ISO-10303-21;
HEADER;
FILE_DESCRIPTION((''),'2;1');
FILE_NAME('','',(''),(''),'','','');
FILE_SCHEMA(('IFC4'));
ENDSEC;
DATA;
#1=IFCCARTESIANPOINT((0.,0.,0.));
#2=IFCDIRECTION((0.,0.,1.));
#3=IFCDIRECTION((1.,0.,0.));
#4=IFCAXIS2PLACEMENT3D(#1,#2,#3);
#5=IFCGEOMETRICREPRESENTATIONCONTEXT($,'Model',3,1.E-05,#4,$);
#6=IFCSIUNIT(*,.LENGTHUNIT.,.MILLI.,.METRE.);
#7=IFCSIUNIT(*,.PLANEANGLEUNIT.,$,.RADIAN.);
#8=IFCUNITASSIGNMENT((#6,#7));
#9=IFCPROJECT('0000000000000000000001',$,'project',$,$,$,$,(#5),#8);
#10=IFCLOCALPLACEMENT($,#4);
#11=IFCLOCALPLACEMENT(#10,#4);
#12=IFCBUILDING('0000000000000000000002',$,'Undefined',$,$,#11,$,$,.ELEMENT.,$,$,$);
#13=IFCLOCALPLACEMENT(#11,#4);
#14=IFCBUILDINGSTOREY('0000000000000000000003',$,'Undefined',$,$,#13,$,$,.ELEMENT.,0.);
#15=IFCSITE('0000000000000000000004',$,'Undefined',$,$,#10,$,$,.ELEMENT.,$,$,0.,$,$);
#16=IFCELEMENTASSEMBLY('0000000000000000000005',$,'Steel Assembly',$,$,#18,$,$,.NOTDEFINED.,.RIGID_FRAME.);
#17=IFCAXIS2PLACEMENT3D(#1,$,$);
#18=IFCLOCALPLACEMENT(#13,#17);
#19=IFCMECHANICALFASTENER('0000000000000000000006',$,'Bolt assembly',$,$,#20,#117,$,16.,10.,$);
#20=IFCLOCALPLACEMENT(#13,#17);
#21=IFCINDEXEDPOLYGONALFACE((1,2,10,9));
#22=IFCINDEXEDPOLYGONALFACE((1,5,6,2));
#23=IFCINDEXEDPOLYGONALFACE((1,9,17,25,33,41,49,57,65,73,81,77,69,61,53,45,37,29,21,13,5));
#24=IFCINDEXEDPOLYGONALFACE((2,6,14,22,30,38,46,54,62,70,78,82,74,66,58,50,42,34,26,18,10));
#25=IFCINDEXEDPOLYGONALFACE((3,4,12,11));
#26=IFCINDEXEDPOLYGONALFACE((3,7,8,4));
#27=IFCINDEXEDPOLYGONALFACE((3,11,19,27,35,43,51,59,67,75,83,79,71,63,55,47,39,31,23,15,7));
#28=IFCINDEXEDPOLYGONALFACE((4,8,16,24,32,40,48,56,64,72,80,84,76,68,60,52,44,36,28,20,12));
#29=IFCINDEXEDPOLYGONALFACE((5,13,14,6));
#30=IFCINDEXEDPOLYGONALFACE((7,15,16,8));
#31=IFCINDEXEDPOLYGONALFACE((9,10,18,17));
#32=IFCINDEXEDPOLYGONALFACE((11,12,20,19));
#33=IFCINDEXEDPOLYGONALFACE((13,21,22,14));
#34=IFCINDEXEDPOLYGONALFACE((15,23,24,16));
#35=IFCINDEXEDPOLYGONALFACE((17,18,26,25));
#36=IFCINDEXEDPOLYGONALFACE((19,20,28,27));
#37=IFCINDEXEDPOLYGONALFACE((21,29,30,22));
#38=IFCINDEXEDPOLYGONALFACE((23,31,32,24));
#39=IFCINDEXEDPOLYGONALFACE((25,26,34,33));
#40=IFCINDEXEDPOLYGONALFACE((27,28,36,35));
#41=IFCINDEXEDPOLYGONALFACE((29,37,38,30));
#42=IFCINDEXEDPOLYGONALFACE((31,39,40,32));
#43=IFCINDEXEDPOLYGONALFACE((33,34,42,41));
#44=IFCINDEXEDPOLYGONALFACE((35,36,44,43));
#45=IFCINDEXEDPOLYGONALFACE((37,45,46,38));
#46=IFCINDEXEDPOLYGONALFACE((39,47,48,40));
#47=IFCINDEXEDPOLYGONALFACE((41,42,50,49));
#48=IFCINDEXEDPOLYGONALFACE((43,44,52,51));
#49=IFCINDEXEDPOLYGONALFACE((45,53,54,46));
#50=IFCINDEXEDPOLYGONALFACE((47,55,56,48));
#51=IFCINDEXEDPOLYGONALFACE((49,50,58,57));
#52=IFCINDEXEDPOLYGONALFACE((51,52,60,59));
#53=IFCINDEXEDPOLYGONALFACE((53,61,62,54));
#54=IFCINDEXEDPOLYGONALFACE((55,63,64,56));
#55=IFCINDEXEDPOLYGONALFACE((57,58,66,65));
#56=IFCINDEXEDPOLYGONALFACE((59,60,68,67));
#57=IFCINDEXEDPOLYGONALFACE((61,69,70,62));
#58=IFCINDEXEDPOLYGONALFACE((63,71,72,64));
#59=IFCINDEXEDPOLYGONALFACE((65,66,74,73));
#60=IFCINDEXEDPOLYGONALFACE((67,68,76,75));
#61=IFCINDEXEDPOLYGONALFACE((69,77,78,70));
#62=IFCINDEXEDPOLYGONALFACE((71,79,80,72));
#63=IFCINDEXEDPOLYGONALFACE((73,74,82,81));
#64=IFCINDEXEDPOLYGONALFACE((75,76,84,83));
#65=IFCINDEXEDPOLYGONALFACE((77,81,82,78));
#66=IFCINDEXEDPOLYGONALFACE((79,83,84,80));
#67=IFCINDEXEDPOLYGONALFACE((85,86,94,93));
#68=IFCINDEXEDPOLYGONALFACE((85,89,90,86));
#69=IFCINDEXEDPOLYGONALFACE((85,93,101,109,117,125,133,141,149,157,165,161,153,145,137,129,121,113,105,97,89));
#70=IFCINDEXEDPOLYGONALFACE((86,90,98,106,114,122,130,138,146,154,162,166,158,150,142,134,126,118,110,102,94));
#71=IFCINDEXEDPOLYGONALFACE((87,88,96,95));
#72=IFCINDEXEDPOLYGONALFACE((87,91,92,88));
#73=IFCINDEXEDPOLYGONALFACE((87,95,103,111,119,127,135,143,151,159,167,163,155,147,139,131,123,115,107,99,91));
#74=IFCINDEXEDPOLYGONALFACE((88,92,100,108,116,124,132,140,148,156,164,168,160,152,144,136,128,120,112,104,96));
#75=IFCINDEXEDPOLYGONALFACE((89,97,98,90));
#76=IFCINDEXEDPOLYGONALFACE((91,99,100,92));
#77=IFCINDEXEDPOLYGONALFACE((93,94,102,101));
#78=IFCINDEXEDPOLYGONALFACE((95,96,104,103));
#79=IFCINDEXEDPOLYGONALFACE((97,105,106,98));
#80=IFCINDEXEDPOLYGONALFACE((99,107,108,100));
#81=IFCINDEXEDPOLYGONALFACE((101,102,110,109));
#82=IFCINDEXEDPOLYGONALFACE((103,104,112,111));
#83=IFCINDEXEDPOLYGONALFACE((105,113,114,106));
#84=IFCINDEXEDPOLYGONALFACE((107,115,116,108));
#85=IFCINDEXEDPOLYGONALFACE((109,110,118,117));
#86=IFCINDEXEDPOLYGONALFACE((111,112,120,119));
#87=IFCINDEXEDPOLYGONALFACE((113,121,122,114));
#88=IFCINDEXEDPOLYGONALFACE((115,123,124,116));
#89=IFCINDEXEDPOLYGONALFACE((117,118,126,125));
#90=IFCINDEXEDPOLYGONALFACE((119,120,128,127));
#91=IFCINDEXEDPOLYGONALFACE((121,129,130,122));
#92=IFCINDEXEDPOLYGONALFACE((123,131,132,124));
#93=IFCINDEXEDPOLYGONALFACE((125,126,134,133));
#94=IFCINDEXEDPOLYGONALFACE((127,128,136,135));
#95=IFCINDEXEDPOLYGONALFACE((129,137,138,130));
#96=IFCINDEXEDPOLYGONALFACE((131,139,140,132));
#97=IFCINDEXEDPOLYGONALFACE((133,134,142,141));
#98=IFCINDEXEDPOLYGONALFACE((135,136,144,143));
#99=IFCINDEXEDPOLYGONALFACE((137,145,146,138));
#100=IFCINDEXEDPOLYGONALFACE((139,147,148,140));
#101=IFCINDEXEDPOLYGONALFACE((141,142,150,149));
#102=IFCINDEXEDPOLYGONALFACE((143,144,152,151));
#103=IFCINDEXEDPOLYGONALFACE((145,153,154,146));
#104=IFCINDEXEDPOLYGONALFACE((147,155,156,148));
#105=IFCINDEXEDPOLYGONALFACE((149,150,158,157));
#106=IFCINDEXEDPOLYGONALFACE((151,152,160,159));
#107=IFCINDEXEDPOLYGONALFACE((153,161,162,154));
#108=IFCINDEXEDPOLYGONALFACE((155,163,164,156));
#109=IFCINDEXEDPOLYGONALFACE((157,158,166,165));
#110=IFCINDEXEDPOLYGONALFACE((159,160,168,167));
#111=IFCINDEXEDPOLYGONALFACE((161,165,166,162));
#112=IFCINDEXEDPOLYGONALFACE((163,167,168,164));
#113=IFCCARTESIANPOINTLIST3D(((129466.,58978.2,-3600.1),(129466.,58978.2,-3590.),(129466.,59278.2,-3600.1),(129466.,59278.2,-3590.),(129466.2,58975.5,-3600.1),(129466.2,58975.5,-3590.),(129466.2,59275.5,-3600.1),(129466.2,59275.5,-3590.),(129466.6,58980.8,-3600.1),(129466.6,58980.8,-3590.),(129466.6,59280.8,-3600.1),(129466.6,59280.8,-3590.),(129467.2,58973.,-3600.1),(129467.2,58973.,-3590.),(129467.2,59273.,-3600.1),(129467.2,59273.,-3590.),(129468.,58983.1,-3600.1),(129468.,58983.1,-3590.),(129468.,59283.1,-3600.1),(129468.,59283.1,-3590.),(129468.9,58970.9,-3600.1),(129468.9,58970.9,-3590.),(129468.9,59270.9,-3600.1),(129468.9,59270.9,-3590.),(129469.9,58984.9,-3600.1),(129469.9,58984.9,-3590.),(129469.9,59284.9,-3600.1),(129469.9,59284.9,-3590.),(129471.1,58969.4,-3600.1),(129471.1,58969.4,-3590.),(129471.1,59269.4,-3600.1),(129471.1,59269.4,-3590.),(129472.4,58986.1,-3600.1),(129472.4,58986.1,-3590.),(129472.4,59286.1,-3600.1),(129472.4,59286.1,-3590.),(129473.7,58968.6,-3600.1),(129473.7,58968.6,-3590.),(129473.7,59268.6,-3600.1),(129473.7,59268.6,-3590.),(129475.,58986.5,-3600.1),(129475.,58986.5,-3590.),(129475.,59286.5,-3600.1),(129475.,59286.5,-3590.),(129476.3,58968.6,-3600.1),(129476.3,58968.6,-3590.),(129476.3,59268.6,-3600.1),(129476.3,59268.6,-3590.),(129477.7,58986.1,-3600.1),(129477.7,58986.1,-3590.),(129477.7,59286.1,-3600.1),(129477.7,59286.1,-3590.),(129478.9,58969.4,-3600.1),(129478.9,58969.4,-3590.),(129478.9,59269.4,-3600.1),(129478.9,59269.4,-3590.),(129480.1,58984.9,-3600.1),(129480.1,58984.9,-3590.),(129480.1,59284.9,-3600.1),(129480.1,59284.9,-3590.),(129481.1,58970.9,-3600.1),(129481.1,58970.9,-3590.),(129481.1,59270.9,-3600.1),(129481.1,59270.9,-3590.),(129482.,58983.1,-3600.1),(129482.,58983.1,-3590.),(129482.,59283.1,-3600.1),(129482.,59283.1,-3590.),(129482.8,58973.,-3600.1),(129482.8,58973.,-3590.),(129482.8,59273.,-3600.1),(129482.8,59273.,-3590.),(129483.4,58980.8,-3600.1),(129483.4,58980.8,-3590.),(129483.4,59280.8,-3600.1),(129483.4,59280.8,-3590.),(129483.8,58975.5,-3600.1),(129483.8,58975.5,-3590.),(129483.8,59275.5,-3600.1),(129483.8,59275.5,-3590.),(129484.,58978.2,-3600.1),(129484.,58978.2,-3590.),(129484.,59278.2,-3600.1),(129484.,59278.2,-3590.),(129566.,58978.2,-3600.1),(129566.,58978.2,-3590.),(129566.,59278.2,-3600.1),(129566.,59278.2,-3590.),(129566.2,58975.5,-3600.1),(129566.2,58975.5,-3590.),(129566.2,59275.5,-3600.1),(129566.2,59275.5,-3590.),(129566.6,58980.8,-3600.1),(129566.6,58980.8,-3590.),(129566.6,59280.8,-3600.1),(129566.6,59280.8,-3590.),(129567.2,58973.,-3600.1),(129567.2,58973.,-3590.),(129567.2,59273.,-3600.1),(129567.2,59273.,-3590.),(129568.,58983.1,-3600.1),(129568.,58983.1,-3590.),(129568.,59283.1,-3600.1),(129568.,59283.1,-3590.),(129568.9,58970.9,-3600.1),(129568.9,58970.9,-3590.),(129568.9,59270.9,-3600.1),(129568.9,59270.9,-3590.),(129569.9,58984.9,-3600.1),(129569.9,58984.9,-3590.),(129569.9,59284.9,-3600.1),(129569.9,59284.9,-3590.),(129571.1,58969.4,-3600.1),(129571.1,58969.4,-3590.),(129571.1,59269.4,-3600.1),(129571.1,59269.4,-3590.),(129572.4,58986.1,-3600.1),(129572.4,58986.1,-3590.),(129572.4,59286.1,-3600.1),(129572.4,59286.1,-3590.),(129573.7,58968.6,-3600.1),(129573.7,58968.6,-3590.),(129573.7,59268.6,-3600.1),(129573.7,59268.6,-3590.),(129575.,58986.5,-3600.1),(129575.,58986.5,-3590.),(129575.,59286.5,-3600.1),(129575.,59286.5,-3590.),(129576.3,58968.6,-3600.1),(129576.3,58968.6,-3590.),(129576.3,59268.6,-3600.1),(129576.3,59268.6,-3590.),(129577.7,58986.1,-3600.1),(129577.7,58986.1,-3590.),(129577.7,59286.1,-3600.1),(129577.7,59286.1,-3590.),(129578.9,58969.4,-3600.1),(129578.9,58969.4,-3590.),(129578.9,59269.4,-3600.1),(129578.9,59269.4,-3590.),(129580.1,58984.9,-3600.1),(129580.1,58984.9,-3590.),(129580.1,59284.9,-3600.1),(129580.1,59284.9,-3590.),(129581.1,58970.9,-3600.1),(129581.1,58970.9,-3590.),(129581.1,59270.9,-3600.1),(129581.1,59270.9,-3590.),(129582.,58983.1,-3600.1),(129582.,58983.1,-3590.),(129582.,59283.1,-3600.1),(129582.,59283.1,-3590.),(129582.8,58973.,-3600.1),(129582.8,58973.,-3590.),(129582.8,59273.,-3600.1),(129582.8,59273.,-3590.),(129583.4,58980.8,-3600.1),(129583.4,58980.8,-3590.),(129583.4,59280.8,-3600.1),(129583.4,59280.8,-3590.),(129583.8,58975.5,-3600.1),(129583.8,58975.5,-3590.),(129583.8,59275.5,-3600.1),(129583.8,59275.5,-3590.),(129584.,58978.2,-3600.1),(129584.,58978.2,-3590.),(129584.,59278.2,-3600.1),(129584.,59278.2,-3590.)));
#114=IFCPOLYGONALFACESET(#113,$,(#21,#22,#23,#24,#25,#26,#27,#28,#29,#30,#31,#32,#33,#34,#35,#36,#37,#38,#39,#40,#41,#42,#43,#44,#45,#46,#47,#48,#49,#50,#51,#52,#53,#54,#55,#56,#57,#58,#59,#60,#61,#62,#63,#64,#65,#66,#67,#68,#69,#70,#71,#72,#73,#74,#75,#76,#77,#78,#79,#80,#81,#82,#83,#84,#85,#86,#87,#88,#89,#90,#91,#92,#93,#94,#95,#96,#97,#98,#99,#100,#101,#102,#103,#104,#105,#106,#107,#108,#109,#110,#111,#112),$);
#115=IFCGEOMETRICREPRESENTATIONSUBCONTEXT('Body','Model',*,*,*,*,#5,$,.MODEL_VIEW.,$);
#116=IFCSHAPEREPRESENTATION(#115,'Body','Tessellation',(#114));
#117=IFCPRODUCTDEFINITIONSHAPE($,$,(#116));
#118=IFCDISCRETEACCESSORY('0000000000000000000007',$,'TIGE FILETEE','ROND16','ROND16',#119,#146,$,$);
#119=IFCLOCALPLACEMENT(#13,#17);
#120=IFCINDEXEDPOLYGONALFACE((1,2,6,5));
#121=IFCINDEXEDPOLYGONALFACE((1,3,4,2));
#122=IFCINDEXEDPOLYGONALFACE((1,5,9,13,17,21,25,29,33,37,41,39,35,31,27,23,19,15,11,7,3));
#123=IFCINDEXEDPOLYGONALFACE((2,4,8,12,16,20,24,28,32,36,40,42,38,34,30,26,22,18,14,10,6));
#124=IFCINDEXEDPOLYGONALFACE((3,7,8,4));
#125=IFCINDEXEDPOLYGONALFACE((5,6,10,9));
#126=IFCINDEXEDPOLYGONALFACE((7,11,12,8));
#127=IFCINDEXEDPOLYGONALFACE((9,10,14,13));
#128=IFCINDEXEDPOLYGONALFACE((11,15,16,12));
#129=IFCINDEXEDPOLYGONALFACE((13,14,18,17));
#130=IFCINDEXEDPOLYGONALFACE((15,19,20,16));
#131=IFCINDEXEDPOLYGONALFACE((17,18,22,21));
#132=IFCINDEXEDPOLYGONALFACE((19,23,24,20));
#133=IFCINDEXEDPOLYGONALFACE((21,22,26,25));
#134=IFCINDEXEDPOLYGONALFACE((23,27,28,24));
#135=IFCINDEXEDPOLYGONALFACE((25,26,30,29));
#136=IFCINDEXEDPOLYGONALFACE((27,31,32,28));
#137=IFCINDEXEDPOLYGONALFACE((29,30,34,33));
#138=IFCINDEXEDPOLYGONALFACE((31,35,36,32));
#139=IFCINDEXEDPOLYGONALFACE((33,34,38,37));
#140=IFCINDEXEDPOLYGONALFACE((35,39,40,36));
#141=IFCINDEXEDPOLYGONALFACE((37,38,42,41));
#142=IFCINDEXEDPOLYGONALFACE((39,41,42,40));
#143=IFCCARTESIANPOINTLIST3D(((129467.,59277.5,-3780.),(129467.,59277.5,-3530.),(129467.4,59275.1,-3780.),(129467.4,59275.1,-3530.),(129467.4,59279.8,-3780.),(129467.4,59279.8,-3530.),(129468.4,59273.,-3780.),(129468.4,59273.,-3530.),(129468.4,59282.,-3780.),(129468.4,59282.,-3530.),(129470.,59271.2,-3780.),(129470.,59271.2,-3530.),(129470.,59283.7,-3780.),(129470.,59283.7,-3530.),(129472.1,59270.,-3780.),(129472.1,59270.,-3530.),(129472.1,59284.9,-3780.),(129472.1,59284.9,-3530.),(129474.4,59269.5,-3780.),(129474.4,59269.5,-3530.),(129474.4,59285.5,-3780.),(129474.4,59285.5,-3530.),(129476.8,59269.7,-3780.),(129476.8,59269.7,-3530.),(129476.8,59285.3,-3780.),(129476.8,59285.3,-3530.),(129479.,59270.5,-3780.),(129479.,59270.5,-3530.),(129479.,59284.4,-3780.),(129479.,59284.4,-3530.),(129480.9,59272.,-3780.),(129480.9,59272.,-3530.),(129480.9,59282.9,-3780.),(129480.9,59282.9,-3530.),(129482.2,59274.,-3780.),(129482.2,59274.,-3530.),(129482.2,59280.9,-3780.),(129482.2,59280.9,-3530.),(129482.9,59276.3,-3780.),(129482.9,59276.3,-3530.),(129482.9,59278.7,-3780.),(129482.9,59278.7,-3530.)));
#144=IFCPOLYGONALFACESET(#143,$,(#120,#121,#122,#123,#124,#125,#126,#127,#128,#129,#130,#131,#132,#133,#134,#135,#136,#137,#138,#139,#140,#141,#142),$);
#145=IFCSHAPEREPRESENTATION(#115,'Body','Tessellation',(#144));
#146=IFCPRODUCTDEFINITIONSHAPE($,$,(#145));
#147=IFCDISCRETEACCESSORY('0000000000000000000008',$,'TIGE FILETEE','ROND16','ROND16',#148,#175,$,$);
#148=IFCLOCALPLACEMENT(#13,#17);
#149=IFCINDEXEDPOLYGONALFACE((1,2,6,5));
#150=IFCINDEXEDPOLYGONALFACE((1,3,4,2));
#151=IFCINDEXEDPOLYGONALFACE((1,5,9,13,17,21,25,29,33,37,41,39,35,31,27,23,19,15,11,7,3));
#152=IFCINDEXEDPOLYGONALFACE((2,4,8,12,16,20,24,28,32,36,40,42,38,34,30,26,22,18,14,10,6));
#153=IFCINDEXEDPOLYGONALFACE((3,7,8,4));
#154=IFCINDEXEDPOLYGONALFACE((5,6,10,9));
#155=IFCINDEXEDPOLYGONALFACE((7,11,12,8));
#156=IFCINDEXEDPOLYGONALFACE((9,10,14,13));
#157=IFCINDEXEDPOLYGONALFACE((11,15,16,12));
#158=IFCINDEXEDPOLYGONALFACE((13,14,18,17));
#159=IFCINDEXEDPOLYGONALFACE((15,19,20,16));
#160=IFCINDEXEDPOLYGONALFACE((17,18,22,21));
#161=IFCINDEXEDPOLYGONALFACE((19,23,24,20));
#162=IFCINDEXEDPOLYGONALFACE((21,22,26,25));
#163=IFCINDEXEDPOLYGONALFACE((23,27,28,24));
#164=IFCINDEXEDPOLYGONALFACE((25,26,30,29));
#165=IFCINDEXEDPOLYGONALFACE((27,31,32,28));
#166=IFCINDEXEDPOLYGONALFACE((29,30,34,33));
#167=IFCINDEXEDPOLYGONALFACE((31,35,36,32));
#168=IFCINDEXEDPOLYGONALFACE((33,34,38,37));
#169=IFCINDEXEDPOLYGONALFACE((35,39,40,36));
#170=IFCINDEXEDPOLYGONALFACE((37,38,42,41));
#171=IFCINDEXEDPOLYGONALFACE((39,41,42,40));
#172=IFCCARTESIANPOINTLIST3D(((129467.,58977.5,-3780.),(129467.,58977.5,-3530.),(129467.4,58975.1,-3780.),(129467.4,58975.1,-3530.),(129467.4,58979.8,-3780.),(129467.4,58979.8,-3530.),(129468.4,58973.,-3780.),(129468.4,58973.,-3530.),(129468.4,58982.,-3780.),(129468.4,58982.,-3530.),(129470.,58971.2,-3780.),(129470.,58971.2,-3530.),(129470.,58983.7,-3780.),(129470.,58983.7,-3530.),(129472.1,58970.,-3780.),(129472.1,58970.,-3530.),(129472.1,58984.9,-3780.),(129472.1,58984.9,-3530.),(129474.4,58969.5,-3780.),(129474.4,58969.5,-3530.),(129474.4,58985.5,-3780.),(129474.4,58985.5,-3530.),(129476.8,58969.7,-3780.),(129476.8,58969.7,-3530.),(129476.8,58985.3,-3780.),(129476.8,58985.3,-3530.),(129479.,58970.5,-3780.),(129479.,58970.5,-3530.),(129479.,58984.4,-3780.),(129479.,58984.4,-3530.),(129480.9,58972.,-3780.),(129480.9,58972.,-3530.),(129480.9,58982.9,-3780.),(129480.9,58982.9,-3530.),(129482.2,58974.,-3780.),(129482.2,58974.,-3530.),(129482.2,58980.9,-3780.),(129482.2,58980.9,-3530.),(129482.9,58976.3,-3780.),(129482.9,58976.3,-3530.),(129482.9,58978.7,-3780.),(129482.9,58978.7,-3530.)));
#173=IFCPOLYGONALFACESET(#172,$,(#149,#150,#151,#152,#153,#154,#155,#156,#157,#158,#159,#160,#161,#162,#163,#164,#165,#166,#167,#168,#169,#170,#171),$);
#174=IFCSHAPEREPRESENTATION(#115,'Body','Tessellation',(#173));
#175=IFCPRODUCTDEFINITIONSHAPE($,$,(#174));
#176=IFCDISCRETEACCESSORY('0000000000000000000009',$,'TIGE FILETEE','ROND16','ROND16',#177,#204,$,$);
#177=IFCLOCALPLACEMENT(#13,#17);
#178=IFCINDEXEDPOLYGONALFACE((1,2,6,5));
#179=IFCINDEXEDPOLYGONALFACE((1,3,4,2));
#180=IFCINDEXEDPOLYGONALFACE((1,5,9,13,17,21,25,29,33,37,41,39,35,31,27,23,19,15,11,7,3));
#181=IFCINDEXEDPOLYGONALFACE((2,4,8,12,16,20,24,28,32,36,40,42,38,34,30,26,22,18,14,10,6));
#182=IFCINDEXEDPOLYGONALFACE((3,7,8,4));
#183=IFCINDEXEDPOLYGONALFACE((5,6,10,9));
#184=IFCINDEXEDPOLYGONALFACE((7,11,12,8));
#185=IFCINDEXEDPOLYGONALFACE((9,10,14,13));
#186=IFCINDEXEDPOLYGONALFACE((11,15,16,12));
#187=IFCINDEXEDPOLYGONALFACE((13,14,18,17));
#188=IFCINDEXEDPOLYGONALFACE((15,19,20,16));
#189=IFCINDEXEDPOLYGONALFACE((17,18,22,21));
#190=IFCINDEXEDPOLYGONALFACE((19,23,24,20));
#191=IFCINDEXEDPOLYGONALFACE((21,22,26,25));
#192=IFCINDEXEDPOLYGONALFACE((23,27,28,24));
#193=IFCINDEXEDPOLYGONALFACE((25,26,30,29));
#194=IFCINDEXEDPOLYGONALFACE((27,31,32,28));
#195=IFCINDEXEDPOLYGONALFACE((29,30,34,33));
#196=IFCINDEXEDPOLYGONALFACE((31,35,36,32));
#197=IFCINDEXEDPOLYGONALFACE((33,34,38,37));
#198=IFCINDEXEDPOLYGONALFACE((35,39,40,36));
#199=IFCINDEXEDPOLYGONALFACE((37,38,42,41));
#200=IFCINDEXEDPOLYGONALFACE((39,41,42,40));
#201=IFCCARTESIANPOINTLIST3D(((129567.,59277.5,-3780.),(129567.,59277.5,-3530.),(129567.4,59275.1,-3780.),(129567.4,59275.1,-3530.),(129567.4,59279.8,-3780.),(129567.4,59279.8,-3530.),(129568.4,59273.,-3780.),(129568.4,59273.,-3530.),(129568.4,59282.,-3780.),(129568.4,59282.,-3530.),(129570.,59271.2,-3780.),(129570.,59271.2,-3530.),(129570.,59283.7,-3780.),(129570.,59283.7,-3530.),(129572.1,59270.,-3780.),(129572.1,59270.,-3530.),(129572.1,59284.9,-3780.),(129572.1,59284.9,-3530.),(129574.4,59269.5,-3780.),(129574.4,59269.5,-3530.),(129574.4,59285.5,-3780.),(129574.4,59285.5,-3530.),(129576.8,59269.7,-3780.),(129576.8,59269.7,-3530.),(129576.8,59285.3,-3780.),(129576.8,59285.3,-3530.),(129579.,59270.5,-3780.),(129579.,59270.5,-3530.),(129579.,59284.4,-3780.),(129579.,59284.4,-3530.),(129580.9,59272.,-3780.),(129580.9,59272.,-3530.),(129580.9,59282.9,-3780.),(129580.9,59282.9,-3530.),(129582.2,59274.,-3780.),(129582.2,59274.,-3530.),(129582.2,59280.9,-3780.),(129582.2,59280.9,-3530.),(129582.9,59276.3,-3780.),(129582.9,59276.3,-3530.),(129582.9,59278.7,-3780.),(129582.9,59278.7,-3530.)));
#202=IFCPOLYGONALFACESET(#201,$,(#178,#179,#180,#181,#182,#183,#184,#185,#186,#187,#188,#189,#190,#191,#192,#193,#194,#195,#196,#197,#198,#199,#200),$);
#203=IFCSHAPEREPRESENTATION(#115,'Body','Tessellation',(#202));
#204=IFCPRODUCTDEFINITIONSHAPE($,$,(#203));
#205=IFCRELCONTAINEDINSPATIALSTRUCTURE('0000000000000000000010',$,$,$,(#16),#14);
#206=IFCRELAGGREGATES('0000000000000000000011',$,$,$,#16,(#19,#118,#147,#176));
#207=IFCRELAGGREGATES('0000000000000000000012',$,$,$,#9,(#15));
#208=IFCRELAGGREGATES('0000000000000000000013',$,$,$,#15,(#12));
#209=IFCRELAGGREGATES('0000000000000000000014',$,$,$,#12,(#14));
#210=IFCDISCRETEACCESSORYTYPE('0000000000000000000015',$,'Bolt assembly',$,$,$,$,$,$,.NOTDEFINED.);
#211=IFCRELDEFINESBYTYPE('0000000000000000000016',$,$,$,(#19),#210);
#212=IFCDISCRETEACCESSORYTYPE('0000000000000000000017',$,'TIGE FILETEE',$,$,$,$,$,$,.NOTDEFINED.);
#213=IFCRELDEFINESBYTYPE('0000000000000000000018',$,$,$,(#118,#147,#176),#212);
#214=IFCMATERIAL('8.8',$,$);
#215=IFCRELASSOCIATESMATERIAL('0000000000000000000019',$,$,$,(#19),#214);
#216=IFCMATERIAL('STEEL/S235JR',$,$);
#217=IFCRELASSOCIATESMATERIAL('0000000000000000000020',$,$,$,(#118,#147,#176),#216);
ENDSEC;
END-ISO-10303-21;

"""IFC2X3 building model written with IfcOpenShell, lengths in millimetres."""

from ifc_helpers import new_model, si_unit, frame, origin_with_axes, origin_2d_with_axis, place, context, subcontext, project, spatial, circle, extrude, source, transform, mapped, material, type_object, element, aggregate, save


model = new_model("IFC2X3")

# Units and contexts
model_context = context("Model", 3, precision=1e-05, world=origin_with_axes())
body_context = subcontext(model_context, "Body", "Model", "MODEL_VIEW")
ifc_project = project(units=[si_unit("LENGTHUNIT", "METRE", prefix="MILLI"), si_unit("PLANEANGLEUNIT", "RADIAN")], contexts=[model_context])

# Site, building, storey
site_placement = place(None, origin_with_axes())
site = spatial("IfcSite", under=ifc_project, at=site_placement, Name="Undefined", CompositionType="ELEMENT", RefElevation=0.0)
building_placement = place(site_placement, origin_with_axes())
building = spatial("IfcBuilding", under=site, at=building_placement, Name="Undefined", CompositionType="ELEMENT")
storey_placement = place(building_placement, origin_with_axes())
storey = spatial("IfcBuildingStorey", under=building, at=storey_placement, Name="Undefined", CompositionType="ELEMENT", Elevation=0.0)

# Shared definitions
ifc_material_1 = material(Name="STEEL/S235JR")

# Element assembly
assembly_1_placement = place(storey_placement, origin_with_axes())
assembly_1 = element("IfcElementAssembly", 1, at=assembly_1_placement, inside=storey, Name="Steel Assembly", AssemblyPlace="NOTDEFINED", PredefinedType="RIGID_FRAME")
ifc_material_2 = material(Name="8.8")
discrete_accessory_type_1 = type_object("IfcDiscreteAccessoryType", Name="Bolt assembly")

# Mechanical fastener
shared_shape_1 = source(origin_with_axes(), body_context, "Body", "SweptSolid", [
    extrude(circle(Radius=9.0, at=origin_2d_with_axis()), frame((0.0, -20.0, 0.0), z_axis=(0.0, 1.0, 0.0), x_axis=(1.0, 0.0, 0.0)), (0.0, 0.0, 1.0), 10.1),
])
mechanical_fastener_1_placement = place(assembly_1_placement, frame((129525.0, 58977.5, -3610.0), z_axis=(-1.0, 0.0, 0.0), x_axis=(0.0, 1.0, 0.0)))
mechanical_fastener_1 = element("IfcMechanicalFastener", 2, at=mechanical_fastener_1_placement, type_object=discrete_accessory_type_1, material=ifc_material_2, Name="Bolt assembly", NominalDiameter=16.0, NominalLength=10.0, context=body_context, shape_type="MappedRepresentation", body=[
    mapped(shared_shape_1, transform((0.0, 0.0, -50.0))),
    mapped(shared_shape_1, transform((300.0, 0.0, -50.0))),
    mapped(shared_shape_1, transform((0.0, 0.0, 50.0))),
    mapped(shared_shape_1, transform((300.0, 0.0, 50.0))),
])

# Discrete accessories
discrete_accessory_type_2 = type_object("IfcDiscreteAccessoryType", Name="TIGE FILETEE")
discrete_accessory_1_placement = place(assembly_1_placement, frame((129475.0, 59277.5, -3530.0), z_axis=(0.0, -1.0, 0.0), x_axis=(0.0, 0.0, -1.0)))
discrete_accessory_1 = element("IfcDiscreteAccessory", 3, at=discrete_accessory_1_placement, type_object=discrete_accessory_type_2, material=ifc_material_1, Name="TIGE FILETEE", Description="ROND16", ObjectType="ROND16", context=body_context, shape_type="SweptSolid", body=[
    extrude(circle(Radius=8.0, at=origin_2d_with_axis()), frame((250.0, 0.0, 0.0), z_axis=(-1.0, 0.0, 0.0), x_axis=(0.0, -1.0, 0.0)), (0.0, 0.0, 1.0), 250.0),
])
discrete_accessory_2_placement = place(assembly_1_placement, frame((129475.0, 58977.5, -3530.0), z_axis=(0.0, -1.0, 0.0), x_axis=(0.0, 0.0, -1.0)))
discrete_accessory_2 = element("IfcDiscreteAccessory", 4, at=discrete_accessory_2_placement, type_object=discrete_accessory_type_2, material=ifc_material_1, Name="TIGE FILETEE", Description="ROND16", ObjectType="ROND16", context=body_context, shape_type="SweptSolid", body=[
    extrude(circle(Radius=8.0, at=origin_2d_with_axis()), frame((250.0, 0.0, 0.0), z_axis=(-1.0, 0.0, 0.0), x_axis=(0.0, -1.0, 0.0)), (0.0, 0.0, 1.0), 250.0),
])
discrete_accessory_3_placement = place(assembly_1_placement, frame((129575.0, 59277.5, -3530.0), z_axis=(0.0, -1.0, 0.0), x_axis=(0.0, 0.0, -1.0)))
discrete_accessory_3 = element("IfcDiscreteAccessory", 5, at=discrete_accessory_3_placement, type_object=discrete_accessory_type_2, material=ifc_material_1, Name="TIGE FILETEE", Description="ROND16", ObjectType="ROND16", context=body_context, shape_type="SweptSolid", body=[
    extrude(circle(Radius=8.0, at=origin_2d_with_axis()), frame((250.0, 0.0, 0.0), z_axis=(-1.0, 0.0, 0.0), x_axis=(0.0, -1.0, 0.0)), (0.0, 0.0, 1.0), 250.0),
])

aggregate(assembly_1, [mechanical_fastener_1, discrete_accessory_1, discrete_accessory_2, discrete_accessory_3])

save(model, "model.ifc")
